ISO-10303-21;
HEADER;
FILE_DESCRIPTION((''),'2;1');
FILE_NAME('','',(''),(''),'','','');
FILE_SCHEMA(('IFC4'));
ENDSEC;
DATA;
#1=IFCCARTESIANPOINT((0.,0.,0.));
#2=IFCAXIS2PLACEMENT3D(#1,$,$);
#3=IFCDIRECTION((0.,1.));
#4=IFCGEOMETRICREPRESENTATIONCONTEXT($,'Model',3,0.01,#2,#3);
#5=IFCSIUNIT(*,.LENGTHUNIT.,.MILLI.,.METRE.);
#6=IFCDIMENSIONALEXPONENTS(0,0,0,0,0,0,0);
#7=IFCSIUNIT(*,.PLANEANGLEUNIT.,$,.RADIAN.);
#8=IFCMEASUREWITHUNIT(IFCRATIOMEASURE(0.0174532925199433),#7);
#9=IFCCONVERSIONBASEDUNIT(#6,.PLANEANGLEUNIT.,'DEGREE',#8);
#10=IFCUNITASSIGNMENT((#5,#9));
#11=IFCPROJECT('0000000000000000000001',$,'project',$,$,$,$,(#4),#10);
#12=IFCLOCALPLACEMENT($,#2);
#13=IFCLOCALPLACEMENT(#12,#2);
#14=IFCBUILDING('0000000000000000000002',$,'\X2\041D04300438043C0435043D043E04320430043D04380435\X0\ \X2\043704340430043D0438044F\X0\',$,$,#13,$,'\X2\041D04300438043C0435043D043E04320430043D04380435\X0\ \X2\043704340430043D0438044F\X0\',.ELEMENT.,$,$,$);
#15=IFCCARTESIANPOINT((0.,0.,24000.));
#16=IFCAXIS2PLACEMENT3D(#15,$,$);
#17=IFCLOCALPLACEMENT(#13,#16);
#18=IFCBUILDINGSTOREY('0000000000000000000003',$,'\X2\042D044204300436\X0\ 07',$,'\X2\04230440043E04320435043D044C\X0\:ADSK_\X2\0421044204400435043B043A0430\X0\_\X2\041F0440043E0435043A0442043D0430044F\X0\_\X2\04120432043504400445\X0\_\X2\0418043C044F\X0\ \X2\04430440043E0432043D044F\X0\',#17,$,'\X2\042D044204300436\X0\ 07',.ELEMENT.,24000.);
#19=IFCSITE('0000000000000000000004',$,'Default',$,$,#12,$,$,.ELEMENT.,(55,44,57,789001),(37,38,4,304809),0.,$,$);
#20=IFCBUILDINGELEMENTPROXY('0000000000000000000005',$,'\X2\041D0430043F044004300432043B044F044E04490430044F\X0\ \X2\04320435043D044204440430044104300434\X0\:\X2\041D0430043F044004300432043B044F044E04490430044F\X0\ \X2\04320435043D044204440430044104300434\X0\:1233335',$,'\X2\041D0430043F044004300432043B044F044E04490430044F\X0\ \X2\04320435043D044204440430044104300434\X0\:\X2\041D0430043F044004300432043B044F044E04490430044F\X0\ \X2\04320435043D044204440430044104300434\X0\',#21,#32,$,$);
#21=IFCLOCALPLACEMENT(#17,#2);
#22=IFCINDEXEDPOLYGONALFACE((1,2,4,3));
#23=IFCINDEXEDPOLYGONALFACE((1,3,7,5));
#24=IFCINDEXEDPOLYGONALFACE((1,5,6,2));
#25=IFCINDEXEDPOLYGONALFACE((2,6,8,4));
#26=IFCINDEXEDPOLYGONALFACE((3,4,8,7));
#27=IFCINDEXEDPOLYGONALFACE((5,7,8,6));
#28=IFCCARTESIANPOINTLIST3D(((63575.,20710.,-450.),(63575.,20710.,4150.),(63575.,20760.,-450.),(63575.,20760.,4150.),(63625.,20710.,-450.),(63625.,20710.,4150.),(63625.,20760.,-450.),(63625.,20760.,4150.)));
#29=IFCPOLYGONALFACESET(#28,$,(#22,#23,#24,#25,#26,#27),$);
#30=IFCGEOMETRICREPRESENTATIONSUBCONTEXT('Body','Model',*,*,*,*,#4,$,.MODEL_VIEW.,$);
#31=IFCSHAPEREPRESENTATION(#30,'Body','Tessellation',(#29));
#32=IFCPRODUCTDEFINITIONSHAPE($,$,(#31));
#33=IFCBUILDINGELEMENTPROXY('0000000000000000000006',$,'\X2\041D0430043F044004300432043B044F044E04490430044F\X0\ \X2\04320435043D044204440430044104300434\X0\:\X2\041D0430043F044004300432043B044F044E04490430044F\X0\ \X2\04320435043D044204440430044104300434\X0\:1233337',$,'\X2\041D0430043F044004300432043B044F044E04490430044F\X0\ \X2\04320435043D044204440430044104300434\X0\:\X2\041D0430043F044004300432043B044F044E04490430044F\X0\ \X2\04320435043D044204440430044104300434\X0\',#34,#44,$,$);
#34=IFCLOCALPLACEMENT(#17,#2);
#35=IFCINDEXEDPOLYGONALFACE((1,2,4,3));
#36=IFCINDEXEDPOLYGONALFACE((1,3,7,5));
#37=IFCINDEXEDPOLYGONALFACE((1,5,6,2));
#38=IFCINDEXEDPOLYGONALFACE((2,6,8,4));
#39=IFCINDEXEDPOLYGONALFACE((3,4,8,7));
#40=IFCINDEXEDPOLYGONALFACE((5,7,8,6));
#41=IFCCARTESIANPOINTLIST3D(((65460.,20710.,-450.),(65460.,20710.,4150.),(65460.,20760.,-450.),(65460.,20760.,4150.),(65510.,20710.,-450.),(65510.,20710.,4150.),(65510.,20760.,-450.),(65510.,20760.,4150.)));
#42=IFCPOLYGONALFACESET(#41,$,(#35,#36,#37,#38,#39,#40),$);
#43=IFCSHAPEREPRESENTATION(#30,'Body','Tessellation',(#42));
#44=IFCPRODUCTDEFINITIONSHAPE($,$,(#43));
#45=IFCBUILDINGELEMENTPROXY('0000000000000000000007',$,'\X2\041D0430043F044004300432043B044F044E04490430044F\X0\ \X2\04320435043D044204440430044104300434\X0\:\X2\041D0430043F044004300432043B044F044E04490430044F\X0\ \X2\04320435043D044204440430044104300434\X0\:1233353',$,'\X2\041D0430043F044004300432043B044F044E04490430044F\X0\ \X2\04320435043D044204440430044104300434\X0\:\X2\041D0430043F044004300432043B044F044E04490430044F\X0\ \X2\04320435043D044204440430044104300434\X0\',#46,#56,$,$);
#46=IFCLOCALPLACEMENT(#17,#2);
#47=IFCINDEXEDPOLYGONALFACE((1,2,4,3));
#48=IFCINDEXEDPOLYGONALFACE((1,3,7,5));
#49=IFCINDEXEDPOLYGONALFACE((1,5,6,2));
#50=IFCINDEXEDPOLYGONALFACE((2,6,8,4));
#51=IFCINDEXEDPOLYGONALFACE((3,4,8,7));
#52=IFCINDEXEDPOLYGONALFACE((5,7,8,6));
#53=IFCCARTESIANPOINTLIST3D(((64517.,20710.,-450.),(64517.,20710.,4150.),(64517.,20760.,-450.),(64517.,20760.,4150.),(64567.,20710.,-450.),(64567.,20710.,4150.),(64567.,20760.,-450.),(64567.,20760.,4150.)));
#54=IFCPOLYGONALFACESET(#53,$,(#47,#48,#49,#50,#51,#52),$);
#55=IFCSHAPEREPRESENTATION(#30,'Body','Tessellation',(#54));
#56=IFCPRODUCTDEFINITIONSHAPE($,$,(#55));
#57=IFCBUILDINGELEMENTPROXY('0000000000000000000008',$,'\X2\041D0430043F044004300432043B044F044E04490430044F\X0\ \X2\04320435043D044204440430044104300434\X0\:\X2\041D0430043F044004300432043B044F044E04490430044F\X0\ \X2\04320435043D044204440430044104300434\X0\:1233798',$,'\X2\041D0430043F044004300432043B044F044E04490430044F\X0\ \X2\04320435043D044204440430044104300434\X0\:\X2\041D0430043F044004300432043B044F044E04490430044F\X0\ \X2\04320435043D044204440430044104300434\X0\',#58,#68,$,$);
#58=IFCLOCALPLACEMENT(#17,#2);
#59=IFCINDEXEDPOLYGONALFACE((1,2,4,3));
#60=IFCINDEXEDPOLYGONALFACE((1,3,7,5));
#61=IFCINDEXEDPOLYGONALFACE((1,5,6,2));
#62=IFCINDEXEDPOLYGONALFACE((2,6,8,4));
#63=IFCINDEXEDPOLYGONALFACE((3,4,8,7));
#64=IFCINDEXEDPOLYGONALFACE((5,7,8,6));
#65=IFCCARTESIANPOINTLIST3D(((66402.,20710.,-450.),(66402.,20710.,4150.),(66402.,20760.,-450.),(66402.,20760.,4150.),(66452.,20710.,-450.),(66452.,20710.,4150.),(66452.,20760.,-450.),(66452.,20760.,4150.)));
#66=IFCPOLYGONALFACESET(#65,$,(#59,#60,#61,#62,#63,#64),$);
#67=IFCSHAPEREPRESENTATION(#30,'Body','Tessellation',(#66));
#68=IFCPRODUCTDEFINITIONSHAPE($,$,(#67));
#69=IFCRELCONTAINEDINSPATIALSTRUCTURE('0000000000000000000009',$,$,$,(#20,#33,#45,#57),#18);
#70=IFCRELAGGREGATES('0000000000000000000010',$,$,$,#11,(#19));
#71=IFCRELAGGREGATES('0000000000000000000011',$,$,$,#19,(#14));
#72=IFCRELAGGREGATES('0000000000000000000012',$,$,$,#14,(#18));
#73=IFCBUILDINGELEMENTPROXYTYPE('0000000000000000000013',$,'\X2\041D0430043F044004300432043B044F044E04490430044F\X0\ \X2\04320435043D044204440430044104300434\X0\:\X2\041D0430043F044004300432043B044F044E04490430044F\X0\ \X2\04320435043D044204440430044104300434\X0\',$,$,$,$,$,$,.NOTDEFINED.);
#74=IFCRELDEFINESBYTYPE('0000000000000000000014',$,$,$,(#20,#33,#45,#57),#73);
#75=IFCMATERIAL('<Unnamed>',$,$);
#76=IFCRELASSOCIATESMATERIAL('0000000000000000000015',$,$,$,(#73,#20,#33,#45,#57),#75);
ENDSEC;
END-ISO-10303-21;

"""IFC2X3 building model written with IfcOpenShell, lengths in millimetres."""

from ifc_helpers import new_model, entity, si_unit, converted_unit, direction, frame, origin, origin_2d_with_axis, place, context, subcontext, project, spatial, rectangle, extrude, source, transform, mapped, material, type_object, type_shapes, element, save


model = new_model("IFC2X3")

# Units and contexts
model_context = context("Model", 3, precision=0.01, world=origin(), true_north=direction((0.0, 1.0)))
body_context = subcontext(model_context, "Body", "Model", "MODEL_VIEW")
ifc_project = project(units=[si_unit("LENGTHUNIT", "METRE", prefix="MILLI"), converted_unit("PLANEANGLEUNIT", "DEGREE", entity("IfcRatioMeasure", 0.0174532925199433), si_unit("PLANEANGLEUNIT", "RADIAN"), dimensions=[0, 0, 0, 0, 0, 0, 0])], contexts=[model_context])

# Site, building, storey
site_placement = place(None, origin())
site = spatial("IfcSite", under=ifc_project, at=site_placement, Name="Default", CompositionType="ELEMENT", RefLatitude=(55, 44, 57, 789001), RefLongitude=(37, 38, 4, 304809), RefElevation=0.0)
building_placement = place(site_placement, origin())
building = spatial("IfcBuilding", under=site, at=building_placement, Name="Наименование здания", LongName="Наименование здания", CompositionType="ELEMENT")
storey_placement = place(building_placement, frame((0.0, 0.0, 24000.0)))
storey = spatial("IfcBuildingStorey", under=building, at=storey_placement, Name="Этаж 07", ObjectType="Уровень:ADSK_Стрелка_Проектная_Вверх_Имя уровня", LongName="Этаж 07", CompositionType="ELEMENT", Elevation=24000.0)

# Building element proxies
ifc_material_1 = material(Name="<Unnamed>")
building_element_proxy_type_1 = type_object("IfcBuildingElementProxyType", Name="Направляющая вентфасад:Направляющая вентфасад", PredefinedType="NOTDEFINED", material=ifc_material_1)
shared_shape_1 = source(origin(), body_context, "Body", "SweptSolid", [
    extrude(rectangle(XDim=50.0, YDim=50.0, at=origin_2d_with_axis()), frame((25.0, -25.0, 0.0), z_axis=(0.0, 0.0, 1.0), x_axis=(-1.0, 0.0, 0.0)), (0.0, 0.0, 1.0), 4600.0),
])
type_shapes(building_element_proxy_type_1, [shared_shape_1])
for number, where, z_axis, x_axis, name in (
    (1, (63625.0, 20710.0, -450.0), (0.0, 0.0, 1.0), (-1.0, 0.0, 0.0), "Направляющая вентфасад:Направляющая вентфасад:1233335"),
    (2, (65510.0, 20710.0, -450.0), (0.0, 0.0, 1.0), (-1.0, 0.0, 0.0), "Направляющая вентфасад:Направляющая вентфасад:1233337"),
    (3, (64567.0, 20710.0, -450.0), (0.0, 0.0, 1.0), (-1.0, 0.0, 0.0), "Направляющая вентфасад:Направляющая вентфасад:1233353"),
    (4, (66452.0, 20710.0, -450.0), (0.0, 0.0, 1.0), (-1.0, 0.0, 0.0), "Направляющая вентфасад:Направляющая вентфасад:1233798"),
):
    element("IfcBuildingElementProxy", number, at=place(storey_placement, frame(where, z_axis=z_axis, x_axis=x_axis)), inside=storey, type_object=building_element_proxy_type_1, material=ifc_material_1, Name=name, ObjectType="Направляющая вентфасад:Направляющая вентфасад", context=body_context, shape_type="MappedRepresentation", body=[
        mapped(shared_shape_1, transform((0.0, 0.0, 0.0), scale=1.0)),
    ])

save(model, "model.ifc")
